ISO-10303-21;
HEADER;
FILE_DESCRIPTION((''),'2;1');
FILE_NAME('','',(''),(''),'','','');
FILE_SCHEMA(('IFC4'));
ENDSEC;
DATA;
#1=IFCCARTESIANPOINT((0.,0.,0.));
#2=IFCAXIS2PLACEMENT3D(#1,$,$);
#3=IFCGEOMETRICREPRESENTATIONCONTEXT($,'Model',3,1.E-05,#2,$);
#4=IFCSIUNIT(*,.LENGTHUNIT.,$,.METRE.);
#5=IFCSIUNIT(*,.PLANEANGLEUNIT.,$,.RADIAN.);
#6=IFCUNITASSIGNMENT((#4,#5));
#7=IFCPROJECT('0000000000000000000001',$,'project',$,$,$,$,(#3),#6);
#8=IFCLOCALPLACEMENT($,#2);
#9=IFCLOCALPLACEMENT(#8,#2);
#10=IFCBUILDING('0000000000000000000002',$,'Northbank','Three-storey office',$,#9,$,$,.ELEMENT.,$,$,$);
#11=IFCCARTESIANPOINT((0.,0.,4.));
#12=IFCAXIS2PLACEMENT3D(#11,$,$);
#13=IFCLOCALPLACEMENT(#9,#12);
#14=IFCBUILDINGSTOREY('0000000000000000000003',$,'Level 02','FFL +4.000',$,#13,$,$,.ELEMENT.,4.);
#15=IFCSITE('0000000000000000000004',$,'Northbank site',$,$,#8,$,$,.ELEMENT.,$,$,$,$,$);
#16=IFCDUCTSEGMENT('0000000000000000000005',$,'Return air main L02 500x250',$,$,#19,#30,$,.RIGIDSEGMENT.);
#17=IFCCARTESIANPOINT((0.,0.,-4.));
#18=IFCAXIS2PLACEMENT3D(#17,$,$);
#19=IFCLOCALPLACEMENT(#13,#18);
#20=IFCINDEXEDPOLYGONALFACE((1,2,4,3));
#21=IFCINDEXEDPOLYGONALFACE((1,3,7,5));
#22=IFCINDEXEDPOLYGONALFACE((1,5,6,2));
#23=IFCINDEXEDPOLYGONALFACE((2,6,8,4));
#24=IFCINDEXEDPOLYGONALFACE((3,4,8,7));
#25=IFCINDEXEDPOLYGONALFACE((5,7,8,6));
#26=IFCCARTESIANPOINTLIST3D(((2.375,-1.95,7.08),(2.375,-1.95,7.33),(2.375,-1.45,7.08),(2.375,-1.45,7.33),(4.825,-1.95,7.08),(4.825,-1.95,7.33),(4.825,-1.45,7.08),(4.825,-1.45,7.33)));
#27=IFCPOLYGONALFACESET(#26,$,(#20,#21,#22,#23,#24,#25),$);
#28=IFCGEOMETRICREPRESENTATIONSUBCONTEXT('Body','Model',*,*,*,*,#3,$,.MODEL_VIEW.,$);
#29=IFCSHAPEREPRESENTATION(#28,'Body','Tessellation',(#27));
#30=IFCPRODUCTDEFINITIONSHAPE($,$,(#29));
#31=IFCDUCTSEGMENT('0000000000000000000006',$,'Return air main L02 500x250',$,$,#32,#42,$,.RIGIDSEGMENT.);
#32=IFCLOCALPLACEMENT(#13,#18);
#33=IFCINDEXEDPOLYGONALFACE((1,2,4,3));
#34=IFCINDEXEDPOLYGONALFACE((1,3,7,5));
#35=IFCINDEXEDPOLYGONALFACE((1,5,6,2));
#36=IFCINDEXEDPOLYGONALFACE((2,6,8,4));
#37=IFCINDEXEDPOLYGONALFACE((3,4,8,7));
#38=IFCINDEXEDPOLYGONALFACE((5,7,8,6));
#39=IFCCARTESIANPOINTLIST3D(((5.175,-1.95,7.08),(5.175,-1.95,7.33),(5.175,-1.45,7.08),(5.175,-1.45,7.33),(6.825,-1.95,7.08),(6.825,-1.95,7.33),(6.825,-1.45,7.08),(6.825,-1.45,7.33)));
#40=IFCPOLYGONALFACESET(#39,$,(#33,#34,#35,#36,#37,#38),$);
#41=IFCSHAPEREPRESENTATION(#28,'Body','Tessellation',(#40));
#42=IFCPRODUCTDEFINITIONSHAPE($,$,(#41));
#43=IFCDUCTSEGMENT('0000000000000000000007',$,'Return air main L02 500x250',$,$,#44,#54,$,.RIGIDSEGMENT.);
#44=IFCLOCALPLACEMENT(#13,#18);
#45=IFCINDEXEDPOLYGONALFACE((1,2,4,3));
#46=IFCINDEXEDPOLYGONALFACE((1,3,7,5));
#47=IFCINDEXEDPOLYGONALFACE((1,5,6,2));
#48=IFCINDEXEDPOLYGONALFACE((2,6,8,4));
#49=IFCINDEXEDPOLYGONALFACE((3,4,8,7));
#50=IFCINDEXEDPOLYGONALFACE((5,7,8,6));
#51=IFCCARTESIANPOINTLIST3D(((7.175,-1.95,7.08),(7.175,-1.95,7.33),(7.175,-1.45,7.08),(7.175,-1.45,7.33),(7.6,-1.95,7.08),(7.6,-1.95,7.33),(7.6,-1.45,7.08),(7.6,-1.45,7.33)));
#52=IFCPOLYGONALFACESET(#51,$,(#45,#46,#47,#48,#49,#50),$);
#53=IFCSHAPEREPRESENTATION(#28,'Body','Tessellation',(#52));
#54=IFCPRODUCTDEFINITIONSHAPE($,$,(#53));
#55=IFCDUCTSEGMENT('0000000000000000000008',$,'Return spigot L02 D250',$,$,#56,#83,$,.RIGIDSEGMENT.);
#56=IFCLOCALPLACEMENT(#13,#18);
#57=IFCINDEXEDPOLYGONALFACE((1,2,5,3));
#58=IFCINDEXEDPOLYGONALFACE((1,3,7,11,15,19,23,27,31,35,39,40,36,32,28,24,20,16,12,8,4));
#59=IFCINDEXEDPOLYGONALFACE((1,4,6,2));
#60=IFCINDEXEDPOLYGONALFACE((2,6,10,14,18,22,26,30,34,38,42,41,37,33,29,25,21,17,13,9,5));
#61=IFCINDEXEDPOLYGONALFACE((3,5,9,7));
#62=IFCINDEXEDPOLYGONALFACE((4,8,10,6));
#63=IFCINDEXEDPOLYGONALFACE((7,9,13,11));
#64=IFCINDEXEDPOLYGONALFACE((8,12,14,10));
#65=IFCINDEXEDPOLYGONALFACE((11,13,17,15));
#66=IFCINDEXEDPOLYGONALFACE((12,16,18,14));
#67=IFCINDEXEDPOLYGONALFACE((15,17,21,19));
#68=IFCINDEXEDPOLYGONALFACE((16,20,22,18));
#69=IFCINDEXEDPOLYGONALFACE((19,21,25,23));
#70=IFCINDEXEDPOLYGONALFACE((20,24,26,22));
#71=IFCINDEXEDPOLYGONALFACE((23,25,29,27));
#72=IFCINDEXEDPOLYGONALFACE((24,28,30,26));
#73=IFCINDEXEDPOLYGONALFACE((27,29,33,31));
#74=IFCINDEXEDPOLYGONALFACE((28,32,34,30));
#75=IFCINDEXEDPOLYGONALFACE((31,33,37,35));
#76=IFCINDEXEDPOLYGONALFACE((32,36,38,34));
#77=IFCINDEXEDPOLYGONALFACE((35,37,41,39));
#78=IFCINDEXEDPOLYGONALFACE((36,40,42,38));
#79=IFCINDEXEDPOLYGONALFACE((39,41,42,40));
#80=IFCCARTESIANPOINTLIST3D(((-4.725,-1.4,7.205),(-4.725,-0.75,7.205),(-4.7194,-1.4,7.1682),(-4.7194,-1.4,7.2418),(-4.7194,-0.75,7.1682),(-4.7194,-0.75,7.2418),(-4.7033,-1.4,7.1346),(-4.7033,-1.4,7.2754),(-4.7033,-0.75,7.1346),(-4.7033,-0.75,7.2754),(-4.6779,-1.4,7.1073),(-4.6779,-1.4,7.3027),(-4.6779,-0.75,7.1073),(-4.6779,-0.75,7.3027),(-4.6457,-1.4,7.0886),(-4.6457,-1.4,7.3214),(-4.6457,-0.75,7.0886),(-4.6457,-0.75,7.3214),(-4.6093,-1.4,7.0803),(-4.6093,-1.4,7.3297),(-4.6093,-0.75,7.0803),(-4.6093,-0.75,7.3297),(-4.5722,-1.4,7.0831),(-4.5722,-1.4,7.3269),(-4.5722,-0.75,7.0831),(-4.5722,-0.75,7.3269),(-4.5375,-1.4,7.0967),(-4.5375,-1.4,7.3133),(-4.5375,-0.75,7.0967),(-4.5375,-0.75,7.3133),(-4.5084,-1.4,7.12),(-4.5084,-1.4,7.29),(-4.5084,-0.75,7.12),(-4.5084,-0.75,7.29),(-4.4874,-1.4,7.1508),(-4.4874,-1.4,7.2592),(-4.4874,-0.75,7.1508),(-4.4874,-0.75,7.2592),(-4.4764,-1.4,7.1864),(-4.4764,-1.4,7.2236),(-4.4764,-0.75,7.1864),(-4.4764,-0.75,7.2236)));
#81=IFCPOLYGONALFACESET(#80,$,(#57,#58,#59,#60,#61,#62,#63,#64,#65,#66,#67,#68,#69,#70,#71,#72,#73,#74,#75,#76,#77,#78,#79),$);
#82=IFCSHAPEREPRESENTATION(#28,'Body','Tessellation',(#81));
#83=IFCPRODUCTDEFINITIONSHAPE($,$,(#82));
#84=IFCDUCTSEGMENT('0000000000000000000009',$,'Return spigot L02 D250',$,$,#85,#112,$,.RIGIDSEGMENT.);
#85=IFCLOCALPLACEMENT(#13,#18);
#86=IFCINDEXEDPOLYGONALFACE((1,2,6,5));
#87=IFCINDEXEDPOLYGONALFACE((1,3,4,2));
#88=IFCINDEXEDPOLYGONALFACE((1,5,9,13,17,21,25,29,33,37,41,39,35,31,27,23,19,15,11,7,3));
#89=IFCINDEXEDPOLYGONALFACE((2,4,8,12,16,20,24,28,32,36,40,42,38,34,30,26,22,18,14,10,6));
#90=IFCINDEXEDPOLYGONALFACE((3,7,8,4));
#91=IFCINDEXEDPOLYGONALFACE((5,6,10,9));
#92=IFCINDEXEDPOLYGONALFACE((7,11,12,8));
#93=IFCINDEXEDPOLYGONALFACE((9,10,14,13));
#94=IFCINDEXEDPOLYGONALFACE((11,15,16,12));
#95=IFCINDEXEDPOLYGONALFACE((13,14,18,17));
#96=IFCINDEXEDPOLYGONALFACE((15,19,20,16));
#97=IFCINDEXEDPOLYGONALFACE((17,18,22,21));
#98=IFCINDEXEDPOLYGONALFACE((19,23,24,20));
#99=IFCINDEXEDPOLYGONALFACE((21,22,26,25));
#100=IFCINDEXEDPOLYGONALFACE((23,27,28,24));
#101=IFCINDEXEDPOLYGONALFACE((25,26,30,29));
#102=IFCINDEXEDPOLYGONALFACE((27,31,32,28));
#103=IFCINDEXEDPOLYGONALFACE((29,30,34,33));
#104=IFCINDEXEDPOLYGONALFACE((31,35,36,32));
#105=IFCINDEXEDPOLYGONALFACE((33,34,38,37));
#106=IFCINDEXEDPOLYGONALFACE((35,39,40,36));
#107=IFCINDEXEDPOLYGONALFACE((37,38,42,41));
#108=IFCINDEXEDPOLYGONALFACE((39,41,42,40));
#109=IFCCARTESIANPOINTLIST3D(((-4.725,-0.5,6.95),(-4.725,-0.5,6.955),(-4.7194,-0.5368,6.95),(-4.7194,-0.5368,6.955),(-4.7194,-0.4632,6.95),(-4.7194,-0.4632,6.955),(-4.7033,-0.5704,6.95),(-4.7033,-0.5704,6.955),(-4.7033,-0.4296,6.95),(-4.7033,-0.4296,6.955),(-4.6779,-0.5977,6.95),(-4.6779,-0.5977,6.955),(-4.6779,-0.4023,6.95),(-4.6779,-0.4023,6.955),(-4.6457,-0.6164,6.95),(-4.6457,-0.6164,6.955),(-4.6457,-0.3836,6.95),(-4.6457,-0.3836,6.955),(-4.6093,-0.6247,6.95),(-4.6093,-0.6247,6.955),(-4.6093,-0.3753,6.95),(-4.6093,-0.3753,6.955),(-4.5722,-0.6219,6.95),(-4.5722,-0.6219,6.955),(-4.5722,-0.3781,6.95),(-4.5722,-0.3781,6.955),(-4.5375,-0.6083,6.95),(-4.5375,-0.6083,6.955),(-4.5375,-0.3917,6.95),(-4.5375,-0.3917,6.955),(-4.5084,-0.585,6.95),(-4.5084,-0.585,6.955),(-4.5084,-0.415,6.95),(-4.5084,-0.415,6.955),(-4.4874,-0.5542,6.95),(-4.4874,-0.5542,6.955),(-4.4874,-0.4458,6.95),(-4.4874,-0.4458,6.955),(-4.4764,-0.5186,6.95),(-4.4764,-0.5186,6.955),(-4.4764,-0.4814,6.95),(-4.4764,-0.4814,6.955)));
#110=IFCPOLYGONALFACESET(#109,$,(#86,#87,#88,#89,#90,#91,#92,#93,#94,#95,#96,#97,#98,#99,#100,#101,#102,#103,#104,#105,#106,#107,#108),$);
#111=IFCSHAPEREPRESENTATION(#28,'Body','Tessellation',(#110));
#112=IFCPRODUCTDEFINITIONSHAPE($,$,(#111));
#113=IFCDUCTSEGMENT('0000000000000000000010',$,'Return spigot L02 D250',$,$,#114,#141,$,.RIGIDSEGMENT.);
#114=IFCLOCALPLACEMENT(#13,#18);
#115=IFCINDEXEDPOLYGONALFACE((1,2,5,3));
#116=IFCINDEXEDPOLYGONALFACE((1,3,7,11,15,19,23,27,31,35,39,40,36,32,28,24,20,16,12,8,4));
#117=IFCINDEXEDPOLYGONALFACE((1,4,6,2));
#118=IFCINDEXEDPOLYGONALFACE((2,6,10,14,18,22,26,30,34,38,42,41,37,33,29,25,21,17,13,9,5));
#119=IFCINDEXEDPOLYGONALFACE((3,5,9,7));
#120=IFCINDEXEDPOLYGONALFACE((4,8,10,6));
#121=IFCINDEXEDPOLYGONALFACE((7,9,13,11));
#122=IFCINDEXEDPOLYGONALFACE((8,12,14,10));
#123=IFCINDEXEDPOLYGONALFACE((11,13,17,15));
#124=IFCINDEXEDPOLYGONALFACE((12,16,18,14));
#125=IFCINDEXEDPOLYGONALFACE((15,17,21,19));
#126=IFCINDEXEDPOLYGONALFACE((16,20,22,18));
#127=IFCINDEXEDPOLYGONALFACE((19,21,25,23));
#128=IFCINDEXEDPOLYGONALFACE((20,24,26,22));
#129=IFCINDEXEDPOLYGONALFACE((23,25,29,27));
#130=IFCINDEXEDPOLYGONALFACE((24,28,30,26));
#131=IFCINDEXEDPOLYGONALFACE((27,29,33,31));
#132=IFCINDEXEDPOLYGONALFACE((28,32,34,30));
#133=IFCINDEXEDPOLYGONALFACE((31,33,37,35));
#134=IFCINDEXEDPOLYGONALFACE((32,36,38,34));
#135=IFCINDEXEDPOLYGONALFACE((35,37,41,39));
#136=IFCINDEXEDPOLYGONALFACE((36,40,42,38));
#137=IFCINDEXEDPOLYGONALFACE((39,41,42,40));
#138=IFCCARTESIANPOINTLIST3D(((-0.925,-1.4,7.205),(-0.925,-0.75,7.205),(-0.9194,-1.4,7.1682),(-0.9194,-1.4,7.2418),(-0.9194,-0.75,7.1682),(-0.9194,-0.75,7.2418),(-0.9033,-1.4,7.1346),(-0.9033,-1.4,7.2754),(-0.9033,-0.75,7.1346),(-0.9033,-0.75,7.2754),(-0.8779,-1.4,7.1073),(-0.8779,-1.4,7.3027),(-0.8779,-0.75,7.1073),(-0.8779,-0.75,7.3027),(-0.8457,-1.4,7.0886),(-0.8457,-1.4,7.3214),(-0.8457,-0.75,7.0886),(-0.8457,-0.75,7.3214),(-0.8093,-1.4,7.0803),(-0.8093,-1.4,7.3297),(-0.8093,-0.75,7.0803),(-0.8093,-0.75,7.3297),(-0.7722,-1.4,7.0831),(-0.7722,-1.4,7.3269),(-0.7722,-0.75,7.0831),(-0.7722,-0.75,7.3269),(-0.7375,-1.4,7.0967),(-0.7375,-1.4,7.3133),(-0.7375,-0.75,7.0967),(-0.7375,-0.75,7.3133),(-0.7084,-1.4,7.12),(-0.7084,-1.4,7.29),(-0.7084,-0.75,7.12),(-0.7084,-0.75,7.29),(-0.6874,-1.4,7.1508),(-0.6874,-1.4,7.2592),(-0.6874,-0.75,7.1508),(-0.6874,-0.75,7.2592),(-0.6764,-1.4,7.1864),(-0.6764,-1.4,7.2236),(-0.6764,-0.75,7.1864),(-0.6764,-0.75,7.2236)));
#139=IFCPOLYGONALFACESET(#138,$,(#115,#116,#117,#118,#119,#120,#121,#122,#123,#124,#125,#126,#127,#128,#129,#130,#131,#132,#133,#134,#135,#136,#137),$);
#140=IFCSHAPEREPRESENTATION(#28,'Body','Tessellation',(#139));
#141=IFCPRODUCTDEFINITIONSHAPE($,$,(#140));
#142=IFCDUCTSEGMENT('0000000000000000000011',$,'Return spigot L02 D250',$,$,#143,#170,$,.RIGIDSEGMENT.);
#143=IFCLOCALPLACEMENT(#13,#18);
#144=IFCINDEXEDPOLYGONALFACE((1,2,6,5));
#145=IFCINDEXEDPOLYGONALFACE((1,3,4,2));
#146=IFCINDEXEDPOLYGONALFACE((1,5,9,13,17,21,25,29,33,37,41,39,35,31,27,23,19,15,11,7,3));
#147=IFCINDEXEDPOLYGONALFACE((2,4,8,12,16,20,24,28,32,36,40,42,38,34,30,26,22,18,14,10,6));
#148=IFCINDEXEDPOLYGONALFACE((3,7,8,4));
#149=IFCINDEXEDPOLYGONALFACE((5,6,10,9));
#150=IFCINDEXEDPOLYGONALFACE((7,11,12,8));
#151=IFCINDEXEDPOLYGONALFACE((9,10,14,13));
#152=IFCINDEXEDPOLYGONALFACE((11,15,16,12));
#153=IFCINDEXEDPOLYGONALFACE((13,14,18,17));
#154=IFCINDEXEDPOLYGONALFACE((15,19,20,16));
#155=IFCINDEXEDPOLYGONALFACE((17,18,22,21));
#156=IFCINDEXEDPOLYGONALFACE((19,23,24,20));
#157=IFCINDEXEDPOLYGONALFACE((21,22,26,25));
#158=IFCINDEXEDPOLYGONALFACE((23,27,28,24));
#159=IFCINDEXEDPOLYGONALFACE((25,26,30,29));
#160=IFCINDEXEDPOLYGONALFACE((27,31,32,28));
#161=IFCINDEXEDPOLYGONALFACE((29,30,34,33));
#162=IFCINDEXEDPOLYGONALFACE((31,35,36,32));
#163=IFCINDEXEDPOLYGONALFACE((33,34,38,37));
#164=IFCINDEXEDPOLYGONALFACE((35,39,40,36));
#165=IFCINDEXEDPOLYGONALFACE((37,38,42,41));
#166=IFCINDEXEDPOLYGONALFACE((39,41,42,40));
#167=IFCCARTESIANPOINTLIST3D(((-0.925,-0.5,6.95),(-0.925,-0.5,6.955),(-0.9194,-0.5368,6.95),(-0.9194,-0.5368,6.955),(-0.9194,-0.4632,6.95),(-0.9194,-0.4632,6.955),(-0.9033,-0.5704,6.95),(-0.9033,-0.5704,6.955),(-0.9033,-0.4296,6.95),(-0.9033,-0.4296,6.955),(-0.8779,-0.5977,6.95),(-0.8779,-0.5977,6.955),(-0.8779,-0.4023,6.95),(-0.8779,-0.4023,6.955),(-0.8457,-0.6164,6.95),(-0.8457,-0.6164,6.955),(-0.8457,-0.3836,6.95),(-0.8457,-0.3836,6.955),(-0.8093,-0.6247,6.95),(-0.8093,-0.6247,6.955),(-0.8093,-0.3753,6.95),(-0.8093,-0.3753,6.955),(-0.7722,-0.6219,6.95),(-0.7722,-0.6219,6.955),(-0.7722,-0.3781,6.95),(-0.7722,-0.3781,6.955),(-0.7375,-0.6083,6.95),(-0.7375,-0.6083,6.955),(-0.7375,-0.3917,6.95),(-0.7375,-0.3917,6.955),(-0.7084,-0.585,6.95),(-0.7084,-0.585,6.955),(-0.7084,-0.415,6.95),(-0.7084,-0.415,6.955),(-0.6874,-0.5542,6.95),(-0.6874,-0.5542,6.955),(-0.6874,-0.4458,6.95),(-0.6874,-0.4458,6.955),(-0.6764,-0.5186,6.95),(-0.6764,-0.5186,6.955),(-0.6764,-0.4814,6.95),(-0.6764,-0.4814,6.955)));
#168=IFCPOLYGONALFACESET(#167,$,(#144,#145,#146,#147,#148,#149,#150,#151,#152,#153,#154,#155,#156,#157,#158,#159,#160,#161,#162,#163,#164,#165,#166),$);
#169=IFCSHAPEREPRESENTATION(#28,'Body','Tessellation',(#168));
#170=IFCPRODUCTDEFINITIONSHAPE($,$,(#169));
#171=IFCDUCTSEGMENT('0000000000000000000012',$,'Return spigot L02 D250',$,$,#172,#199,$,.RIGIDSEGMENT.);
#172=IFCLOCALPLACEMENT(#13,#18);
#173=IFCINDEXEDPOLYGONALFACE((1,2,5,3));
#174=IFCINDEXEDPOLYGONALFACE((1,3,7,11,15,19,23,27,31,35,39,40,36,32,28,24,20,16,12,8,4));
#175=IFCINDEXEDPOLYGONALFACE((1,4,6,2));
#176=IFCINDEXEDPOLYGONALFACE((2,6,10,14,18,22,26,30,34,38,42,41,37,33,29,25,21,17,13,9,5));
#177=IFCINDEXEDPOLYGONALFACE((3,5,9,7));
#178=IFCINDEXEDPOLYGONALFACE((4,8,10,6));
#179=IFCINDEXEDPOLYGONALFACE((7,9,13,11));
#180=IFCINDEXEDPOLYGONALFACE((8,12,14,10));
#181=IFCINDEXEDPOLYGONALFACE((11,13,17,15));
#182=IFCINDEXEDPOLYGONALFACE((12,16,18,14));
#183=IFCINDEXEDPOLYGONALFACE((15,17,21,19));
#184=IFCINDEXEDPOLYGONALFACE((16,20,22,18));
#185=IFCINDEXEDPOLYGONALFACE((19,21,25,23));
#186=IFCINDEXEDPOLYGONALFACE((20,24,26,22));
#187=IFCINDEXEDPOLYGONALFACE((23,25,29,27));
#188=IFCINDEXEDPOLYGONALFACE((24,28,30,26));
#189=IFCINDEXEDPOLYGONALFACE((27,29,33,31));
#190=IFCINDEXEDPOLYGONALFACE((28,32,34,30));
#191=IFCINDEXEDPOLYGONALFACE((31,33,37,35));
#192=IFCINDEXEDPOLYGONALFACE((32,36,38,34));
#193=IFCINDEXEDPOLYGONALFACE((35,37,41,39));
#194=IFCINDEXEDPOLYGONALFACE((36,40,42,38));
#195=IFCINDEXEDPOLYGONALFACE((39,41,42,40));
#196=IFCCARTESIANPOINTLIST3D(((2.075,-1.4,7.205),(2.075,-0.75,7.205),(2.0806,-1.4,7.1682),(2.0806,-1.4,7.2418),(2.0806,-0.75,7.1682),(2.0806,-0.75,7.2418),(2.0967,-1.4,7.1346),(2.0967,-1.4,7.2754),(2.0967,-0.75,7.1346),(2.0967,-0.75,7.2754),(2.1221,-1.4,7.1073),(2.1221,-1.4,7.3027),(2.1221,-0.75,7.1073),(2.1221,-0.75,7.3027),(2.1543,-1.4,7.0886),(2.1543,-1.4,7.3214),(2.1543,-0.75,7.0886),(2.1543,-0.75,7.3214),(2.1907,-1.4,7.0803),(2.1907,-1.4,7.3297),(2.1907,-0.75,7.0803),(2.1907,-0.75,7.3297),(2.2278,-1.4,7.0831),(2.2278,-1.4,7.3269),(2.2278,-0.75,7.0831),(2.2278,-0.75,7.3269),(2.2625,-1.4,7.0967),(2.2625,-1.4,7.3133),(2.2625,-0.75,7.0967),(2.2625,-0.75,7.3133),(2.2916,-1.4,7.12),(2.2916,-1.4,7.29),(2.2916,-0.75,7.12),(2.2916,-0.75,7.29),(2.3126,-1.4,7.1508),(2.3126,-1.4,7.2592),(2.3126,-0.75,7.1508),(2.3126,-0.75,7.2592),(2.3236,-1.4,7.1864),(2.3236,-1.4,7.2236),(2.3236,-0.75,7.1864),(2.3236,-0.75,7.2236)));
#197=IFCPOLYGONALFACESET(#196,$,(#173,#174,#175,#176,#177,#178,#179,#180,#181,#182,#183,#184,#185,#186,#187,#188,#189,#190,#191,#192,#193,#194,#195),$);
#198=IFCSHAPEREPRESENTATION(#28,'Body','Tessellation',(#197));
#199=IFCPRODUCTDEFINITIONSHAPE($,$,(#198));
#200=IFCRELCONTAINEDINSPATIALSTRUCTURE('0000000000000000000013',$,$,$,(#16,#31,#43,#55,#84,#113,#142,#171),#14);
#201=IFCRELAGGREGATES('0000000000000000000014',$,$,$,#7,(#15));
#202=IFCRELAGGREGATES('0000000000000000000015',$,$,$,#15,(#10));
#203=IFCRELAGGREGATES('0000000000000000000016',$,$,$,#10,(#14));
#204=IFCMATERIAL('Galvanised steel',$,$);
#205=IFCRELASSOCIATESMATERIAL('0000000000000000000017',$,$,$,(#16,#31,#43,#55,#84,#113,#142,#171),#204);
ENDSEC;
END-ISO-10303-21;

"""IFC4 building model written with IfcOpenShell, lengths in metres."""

from ifc_helpers import new_model, si_unit, frame, origin, place, context, subcontext, project, spatial, rectangle, circle, extrude, material, element, save


model = new_model("IFC4")

# Units and contexts
model_context = context("Model", 3, precision=1e-05, world=origin())
body_context = subcontext(model_context, "Body", "Model", "MODEL_VIEW")
ifc_project = project(units=[si_unit("LENGTHUNIT", "METRE"), si_unit("PLANEANGLEUNIT", "RADIAN")], contexts=[model_context])

# Site, building, storey
site_placement = place(None, origin())
site = spatial("IfcSite", under=ifc_project, at=site_placement, Name="Northbank site", CompositionType="ELEMENT")
building_placement = place(site_placement, origin())
building = spatial("IfcBuilding", under=site, at=building_placement, Name="Northbank", Description="Three-storey office", CompositionType="ELEMENT")
storey_placement = place(building_placement, frame((0.0, 0.0, 4.0)))
storey = spatial("IfcBuildingStorey", under=building, at=storey_placement, Name="Level 02", Description="FFL +4.000", CompositionType="ELEMENT", Elevation=4.0)

# Duct segment
ifc_material_1 = material(Name="Galvanised steel")
duct_segment_1_placement = place(storey_placement, frame((0.0, 0.0, -4.0)))
element("IfcDuctSegment", 1, at=duct_segment_1_placement, inside=storey, material=ifc_material_1, Name="Return air main L02 500x250", PredefinedType="RIGIDSEGMENT", context=body_context, shape_type="SweptSolid", body=[
    extrude(rectangle(XDim=0.5, YDim=0.25), frame((2.375, -1.7, 7.205), z_axis=(1.0, 0.0, 0.0), x_axis=(0.0, 1.0, 0.0)), (0.0, 0.0, 1.0), 2.45),
])

# Duct segments
duct_segment_2_placement = place(storey_placement, frame((0.0, 0.0, -4.0)))
element("IfcDuctSegment", 2, at=duct_segment_2_placement, inside=storey, material=ifc_material_1, Name="Return air main L02 500x250", PredefinedType="RIGIDSEGMENT", context=body_context, shape_type="SweptSolid", body=[
    extrude(rectangle(XDim=0.5, YDim=0.25), frame((5.175, -1.7, 7.205), z_axis=(1.0, 0.0, 0.0), x_axis=(0.0, 1.0, 0.0)), (0.0, 0.0, 1.0), 1.65),
])
duct_segment_3_placement = place(storey_placement, frame((0.0, 0.0, -4.0)))
element("IfcDuctSegment", 3, at=duct_segment_3_placement, inside=storey, material=ifc_material_1, Name="Return air main L02 500x250", PredefinedType="RIGIDSEGMENT", context=body_context, shape_type="SweptSolid", body=[
    extrude(rectangle(XDim=0.5, YDim=0.25), frame((7.175, -1.7, 7.205), z_axis=(1.0, 0.0, 0.0), x_axis=(0.0, 1.0, 0.0)), (0.0, 0.0, 1.0), 0.425),
])

# Duct segments
duct_segment_4_placement = place(storey_placement, frame((0.0, 0.0, -4.0)))
element("IfcDuctSegment", 4, at=duct_segment_4_placement, inside=storey, material=ifc_material_1, Name="Return spigot L02 D250", PredefinedType="RIGIDSEGMENT", context=body_context, shape_type="SweptSolid", body=[
    extrude(circle(Radius=0.125), frame((-4.6, -1.4, 7.205), z_axis=(0.0, 1.0, 0.0), x_axis=(-1.0, 0.0, 0.0)), (0.0, 0.0, 1.0), 0.65),
])
duct_segment_5_placement = place(storey_placement, frame((0.0, 0.0, -4.0)))
element("IfcDuctSegment", 5, at=duct_segment_5_placement, inside=storey, material=ifc_material_1, Name="Return spigot L02 D250", PredefinedType="RIGIDSEGMENT", context=body_context, shape_type="SweptSolid", body=[
    extrude(circle(Radius=0.125), frame((-4.6, -0.5, 6.955), z_axis=(0.0, 0.0, -1.0), x_axis=(-1.0, 0.0, 0.0)), (0.0, 0.0, 1.0), 0.005),
])

# Duct segments
duct_segment_6_placement = place(storey_placement, frame((0.0, 0.0, -4.0)))
element("IfcDuctSegment", 6, at=duct_segment_6_placement, inside=storey, material=ifc_material_1, Name="Return spigot L02 D250", PredefinedType="RIGIDSEGMENT", context=body_context, shape_type="SweptSolid", body=[
    extrude(circle(Radius=0.125), frame((-0.8, -1.4, 7.205), z_axis=(0.0, 1.0, 0.0), x_axis=(-1.0, 0.0, 0.0)), (0.0, 0.0, 1.0), 0.65),
])
duct_segment_7_placement = place(storey_placement, frame((0.0, 0.0, -4.0)))
element("IfcDuctSegment", 7, at=duct_segment_7_placement, inside=storey, material=ifc_material_1, Name="Return spigot L02 D250", PredefinedType="RIGIDSEGMENT", context=body_context, shape_type="SweptSolid", body=[
    extrude(circle(Radius=0.125), frame((-0.8, -0.5, 6.955), z_axis=(0.0, 0.0, -1.0), x_axis=(-1.0, 0.0, 0.0)), (0.0, 0.0, 1.0), 0.005),
])

# Duct segment
duct_segment_8_placement = place(storey_placement, frame((0.0, 0.0, -4.0)))
element("IfcDuctSegment", 8, at=duct_segment_8_placement, inside=storey, material=ifc_material_1, Name="Return spigot L02 D250", PredefinedType="RIGIDSEGMENT", context=body_context, shape_type="SweptSolid", body=[
    extrude(circle(Radius=0.125), frame((2.2, -1.4, 7.205), z_axis=(0.0, 1.0, 0.0), x_axis=(-1.0, 0.0, 0.0)), (0.0, 0.0, 1.0), 0.65),
])

save(model, "model.ifc")
